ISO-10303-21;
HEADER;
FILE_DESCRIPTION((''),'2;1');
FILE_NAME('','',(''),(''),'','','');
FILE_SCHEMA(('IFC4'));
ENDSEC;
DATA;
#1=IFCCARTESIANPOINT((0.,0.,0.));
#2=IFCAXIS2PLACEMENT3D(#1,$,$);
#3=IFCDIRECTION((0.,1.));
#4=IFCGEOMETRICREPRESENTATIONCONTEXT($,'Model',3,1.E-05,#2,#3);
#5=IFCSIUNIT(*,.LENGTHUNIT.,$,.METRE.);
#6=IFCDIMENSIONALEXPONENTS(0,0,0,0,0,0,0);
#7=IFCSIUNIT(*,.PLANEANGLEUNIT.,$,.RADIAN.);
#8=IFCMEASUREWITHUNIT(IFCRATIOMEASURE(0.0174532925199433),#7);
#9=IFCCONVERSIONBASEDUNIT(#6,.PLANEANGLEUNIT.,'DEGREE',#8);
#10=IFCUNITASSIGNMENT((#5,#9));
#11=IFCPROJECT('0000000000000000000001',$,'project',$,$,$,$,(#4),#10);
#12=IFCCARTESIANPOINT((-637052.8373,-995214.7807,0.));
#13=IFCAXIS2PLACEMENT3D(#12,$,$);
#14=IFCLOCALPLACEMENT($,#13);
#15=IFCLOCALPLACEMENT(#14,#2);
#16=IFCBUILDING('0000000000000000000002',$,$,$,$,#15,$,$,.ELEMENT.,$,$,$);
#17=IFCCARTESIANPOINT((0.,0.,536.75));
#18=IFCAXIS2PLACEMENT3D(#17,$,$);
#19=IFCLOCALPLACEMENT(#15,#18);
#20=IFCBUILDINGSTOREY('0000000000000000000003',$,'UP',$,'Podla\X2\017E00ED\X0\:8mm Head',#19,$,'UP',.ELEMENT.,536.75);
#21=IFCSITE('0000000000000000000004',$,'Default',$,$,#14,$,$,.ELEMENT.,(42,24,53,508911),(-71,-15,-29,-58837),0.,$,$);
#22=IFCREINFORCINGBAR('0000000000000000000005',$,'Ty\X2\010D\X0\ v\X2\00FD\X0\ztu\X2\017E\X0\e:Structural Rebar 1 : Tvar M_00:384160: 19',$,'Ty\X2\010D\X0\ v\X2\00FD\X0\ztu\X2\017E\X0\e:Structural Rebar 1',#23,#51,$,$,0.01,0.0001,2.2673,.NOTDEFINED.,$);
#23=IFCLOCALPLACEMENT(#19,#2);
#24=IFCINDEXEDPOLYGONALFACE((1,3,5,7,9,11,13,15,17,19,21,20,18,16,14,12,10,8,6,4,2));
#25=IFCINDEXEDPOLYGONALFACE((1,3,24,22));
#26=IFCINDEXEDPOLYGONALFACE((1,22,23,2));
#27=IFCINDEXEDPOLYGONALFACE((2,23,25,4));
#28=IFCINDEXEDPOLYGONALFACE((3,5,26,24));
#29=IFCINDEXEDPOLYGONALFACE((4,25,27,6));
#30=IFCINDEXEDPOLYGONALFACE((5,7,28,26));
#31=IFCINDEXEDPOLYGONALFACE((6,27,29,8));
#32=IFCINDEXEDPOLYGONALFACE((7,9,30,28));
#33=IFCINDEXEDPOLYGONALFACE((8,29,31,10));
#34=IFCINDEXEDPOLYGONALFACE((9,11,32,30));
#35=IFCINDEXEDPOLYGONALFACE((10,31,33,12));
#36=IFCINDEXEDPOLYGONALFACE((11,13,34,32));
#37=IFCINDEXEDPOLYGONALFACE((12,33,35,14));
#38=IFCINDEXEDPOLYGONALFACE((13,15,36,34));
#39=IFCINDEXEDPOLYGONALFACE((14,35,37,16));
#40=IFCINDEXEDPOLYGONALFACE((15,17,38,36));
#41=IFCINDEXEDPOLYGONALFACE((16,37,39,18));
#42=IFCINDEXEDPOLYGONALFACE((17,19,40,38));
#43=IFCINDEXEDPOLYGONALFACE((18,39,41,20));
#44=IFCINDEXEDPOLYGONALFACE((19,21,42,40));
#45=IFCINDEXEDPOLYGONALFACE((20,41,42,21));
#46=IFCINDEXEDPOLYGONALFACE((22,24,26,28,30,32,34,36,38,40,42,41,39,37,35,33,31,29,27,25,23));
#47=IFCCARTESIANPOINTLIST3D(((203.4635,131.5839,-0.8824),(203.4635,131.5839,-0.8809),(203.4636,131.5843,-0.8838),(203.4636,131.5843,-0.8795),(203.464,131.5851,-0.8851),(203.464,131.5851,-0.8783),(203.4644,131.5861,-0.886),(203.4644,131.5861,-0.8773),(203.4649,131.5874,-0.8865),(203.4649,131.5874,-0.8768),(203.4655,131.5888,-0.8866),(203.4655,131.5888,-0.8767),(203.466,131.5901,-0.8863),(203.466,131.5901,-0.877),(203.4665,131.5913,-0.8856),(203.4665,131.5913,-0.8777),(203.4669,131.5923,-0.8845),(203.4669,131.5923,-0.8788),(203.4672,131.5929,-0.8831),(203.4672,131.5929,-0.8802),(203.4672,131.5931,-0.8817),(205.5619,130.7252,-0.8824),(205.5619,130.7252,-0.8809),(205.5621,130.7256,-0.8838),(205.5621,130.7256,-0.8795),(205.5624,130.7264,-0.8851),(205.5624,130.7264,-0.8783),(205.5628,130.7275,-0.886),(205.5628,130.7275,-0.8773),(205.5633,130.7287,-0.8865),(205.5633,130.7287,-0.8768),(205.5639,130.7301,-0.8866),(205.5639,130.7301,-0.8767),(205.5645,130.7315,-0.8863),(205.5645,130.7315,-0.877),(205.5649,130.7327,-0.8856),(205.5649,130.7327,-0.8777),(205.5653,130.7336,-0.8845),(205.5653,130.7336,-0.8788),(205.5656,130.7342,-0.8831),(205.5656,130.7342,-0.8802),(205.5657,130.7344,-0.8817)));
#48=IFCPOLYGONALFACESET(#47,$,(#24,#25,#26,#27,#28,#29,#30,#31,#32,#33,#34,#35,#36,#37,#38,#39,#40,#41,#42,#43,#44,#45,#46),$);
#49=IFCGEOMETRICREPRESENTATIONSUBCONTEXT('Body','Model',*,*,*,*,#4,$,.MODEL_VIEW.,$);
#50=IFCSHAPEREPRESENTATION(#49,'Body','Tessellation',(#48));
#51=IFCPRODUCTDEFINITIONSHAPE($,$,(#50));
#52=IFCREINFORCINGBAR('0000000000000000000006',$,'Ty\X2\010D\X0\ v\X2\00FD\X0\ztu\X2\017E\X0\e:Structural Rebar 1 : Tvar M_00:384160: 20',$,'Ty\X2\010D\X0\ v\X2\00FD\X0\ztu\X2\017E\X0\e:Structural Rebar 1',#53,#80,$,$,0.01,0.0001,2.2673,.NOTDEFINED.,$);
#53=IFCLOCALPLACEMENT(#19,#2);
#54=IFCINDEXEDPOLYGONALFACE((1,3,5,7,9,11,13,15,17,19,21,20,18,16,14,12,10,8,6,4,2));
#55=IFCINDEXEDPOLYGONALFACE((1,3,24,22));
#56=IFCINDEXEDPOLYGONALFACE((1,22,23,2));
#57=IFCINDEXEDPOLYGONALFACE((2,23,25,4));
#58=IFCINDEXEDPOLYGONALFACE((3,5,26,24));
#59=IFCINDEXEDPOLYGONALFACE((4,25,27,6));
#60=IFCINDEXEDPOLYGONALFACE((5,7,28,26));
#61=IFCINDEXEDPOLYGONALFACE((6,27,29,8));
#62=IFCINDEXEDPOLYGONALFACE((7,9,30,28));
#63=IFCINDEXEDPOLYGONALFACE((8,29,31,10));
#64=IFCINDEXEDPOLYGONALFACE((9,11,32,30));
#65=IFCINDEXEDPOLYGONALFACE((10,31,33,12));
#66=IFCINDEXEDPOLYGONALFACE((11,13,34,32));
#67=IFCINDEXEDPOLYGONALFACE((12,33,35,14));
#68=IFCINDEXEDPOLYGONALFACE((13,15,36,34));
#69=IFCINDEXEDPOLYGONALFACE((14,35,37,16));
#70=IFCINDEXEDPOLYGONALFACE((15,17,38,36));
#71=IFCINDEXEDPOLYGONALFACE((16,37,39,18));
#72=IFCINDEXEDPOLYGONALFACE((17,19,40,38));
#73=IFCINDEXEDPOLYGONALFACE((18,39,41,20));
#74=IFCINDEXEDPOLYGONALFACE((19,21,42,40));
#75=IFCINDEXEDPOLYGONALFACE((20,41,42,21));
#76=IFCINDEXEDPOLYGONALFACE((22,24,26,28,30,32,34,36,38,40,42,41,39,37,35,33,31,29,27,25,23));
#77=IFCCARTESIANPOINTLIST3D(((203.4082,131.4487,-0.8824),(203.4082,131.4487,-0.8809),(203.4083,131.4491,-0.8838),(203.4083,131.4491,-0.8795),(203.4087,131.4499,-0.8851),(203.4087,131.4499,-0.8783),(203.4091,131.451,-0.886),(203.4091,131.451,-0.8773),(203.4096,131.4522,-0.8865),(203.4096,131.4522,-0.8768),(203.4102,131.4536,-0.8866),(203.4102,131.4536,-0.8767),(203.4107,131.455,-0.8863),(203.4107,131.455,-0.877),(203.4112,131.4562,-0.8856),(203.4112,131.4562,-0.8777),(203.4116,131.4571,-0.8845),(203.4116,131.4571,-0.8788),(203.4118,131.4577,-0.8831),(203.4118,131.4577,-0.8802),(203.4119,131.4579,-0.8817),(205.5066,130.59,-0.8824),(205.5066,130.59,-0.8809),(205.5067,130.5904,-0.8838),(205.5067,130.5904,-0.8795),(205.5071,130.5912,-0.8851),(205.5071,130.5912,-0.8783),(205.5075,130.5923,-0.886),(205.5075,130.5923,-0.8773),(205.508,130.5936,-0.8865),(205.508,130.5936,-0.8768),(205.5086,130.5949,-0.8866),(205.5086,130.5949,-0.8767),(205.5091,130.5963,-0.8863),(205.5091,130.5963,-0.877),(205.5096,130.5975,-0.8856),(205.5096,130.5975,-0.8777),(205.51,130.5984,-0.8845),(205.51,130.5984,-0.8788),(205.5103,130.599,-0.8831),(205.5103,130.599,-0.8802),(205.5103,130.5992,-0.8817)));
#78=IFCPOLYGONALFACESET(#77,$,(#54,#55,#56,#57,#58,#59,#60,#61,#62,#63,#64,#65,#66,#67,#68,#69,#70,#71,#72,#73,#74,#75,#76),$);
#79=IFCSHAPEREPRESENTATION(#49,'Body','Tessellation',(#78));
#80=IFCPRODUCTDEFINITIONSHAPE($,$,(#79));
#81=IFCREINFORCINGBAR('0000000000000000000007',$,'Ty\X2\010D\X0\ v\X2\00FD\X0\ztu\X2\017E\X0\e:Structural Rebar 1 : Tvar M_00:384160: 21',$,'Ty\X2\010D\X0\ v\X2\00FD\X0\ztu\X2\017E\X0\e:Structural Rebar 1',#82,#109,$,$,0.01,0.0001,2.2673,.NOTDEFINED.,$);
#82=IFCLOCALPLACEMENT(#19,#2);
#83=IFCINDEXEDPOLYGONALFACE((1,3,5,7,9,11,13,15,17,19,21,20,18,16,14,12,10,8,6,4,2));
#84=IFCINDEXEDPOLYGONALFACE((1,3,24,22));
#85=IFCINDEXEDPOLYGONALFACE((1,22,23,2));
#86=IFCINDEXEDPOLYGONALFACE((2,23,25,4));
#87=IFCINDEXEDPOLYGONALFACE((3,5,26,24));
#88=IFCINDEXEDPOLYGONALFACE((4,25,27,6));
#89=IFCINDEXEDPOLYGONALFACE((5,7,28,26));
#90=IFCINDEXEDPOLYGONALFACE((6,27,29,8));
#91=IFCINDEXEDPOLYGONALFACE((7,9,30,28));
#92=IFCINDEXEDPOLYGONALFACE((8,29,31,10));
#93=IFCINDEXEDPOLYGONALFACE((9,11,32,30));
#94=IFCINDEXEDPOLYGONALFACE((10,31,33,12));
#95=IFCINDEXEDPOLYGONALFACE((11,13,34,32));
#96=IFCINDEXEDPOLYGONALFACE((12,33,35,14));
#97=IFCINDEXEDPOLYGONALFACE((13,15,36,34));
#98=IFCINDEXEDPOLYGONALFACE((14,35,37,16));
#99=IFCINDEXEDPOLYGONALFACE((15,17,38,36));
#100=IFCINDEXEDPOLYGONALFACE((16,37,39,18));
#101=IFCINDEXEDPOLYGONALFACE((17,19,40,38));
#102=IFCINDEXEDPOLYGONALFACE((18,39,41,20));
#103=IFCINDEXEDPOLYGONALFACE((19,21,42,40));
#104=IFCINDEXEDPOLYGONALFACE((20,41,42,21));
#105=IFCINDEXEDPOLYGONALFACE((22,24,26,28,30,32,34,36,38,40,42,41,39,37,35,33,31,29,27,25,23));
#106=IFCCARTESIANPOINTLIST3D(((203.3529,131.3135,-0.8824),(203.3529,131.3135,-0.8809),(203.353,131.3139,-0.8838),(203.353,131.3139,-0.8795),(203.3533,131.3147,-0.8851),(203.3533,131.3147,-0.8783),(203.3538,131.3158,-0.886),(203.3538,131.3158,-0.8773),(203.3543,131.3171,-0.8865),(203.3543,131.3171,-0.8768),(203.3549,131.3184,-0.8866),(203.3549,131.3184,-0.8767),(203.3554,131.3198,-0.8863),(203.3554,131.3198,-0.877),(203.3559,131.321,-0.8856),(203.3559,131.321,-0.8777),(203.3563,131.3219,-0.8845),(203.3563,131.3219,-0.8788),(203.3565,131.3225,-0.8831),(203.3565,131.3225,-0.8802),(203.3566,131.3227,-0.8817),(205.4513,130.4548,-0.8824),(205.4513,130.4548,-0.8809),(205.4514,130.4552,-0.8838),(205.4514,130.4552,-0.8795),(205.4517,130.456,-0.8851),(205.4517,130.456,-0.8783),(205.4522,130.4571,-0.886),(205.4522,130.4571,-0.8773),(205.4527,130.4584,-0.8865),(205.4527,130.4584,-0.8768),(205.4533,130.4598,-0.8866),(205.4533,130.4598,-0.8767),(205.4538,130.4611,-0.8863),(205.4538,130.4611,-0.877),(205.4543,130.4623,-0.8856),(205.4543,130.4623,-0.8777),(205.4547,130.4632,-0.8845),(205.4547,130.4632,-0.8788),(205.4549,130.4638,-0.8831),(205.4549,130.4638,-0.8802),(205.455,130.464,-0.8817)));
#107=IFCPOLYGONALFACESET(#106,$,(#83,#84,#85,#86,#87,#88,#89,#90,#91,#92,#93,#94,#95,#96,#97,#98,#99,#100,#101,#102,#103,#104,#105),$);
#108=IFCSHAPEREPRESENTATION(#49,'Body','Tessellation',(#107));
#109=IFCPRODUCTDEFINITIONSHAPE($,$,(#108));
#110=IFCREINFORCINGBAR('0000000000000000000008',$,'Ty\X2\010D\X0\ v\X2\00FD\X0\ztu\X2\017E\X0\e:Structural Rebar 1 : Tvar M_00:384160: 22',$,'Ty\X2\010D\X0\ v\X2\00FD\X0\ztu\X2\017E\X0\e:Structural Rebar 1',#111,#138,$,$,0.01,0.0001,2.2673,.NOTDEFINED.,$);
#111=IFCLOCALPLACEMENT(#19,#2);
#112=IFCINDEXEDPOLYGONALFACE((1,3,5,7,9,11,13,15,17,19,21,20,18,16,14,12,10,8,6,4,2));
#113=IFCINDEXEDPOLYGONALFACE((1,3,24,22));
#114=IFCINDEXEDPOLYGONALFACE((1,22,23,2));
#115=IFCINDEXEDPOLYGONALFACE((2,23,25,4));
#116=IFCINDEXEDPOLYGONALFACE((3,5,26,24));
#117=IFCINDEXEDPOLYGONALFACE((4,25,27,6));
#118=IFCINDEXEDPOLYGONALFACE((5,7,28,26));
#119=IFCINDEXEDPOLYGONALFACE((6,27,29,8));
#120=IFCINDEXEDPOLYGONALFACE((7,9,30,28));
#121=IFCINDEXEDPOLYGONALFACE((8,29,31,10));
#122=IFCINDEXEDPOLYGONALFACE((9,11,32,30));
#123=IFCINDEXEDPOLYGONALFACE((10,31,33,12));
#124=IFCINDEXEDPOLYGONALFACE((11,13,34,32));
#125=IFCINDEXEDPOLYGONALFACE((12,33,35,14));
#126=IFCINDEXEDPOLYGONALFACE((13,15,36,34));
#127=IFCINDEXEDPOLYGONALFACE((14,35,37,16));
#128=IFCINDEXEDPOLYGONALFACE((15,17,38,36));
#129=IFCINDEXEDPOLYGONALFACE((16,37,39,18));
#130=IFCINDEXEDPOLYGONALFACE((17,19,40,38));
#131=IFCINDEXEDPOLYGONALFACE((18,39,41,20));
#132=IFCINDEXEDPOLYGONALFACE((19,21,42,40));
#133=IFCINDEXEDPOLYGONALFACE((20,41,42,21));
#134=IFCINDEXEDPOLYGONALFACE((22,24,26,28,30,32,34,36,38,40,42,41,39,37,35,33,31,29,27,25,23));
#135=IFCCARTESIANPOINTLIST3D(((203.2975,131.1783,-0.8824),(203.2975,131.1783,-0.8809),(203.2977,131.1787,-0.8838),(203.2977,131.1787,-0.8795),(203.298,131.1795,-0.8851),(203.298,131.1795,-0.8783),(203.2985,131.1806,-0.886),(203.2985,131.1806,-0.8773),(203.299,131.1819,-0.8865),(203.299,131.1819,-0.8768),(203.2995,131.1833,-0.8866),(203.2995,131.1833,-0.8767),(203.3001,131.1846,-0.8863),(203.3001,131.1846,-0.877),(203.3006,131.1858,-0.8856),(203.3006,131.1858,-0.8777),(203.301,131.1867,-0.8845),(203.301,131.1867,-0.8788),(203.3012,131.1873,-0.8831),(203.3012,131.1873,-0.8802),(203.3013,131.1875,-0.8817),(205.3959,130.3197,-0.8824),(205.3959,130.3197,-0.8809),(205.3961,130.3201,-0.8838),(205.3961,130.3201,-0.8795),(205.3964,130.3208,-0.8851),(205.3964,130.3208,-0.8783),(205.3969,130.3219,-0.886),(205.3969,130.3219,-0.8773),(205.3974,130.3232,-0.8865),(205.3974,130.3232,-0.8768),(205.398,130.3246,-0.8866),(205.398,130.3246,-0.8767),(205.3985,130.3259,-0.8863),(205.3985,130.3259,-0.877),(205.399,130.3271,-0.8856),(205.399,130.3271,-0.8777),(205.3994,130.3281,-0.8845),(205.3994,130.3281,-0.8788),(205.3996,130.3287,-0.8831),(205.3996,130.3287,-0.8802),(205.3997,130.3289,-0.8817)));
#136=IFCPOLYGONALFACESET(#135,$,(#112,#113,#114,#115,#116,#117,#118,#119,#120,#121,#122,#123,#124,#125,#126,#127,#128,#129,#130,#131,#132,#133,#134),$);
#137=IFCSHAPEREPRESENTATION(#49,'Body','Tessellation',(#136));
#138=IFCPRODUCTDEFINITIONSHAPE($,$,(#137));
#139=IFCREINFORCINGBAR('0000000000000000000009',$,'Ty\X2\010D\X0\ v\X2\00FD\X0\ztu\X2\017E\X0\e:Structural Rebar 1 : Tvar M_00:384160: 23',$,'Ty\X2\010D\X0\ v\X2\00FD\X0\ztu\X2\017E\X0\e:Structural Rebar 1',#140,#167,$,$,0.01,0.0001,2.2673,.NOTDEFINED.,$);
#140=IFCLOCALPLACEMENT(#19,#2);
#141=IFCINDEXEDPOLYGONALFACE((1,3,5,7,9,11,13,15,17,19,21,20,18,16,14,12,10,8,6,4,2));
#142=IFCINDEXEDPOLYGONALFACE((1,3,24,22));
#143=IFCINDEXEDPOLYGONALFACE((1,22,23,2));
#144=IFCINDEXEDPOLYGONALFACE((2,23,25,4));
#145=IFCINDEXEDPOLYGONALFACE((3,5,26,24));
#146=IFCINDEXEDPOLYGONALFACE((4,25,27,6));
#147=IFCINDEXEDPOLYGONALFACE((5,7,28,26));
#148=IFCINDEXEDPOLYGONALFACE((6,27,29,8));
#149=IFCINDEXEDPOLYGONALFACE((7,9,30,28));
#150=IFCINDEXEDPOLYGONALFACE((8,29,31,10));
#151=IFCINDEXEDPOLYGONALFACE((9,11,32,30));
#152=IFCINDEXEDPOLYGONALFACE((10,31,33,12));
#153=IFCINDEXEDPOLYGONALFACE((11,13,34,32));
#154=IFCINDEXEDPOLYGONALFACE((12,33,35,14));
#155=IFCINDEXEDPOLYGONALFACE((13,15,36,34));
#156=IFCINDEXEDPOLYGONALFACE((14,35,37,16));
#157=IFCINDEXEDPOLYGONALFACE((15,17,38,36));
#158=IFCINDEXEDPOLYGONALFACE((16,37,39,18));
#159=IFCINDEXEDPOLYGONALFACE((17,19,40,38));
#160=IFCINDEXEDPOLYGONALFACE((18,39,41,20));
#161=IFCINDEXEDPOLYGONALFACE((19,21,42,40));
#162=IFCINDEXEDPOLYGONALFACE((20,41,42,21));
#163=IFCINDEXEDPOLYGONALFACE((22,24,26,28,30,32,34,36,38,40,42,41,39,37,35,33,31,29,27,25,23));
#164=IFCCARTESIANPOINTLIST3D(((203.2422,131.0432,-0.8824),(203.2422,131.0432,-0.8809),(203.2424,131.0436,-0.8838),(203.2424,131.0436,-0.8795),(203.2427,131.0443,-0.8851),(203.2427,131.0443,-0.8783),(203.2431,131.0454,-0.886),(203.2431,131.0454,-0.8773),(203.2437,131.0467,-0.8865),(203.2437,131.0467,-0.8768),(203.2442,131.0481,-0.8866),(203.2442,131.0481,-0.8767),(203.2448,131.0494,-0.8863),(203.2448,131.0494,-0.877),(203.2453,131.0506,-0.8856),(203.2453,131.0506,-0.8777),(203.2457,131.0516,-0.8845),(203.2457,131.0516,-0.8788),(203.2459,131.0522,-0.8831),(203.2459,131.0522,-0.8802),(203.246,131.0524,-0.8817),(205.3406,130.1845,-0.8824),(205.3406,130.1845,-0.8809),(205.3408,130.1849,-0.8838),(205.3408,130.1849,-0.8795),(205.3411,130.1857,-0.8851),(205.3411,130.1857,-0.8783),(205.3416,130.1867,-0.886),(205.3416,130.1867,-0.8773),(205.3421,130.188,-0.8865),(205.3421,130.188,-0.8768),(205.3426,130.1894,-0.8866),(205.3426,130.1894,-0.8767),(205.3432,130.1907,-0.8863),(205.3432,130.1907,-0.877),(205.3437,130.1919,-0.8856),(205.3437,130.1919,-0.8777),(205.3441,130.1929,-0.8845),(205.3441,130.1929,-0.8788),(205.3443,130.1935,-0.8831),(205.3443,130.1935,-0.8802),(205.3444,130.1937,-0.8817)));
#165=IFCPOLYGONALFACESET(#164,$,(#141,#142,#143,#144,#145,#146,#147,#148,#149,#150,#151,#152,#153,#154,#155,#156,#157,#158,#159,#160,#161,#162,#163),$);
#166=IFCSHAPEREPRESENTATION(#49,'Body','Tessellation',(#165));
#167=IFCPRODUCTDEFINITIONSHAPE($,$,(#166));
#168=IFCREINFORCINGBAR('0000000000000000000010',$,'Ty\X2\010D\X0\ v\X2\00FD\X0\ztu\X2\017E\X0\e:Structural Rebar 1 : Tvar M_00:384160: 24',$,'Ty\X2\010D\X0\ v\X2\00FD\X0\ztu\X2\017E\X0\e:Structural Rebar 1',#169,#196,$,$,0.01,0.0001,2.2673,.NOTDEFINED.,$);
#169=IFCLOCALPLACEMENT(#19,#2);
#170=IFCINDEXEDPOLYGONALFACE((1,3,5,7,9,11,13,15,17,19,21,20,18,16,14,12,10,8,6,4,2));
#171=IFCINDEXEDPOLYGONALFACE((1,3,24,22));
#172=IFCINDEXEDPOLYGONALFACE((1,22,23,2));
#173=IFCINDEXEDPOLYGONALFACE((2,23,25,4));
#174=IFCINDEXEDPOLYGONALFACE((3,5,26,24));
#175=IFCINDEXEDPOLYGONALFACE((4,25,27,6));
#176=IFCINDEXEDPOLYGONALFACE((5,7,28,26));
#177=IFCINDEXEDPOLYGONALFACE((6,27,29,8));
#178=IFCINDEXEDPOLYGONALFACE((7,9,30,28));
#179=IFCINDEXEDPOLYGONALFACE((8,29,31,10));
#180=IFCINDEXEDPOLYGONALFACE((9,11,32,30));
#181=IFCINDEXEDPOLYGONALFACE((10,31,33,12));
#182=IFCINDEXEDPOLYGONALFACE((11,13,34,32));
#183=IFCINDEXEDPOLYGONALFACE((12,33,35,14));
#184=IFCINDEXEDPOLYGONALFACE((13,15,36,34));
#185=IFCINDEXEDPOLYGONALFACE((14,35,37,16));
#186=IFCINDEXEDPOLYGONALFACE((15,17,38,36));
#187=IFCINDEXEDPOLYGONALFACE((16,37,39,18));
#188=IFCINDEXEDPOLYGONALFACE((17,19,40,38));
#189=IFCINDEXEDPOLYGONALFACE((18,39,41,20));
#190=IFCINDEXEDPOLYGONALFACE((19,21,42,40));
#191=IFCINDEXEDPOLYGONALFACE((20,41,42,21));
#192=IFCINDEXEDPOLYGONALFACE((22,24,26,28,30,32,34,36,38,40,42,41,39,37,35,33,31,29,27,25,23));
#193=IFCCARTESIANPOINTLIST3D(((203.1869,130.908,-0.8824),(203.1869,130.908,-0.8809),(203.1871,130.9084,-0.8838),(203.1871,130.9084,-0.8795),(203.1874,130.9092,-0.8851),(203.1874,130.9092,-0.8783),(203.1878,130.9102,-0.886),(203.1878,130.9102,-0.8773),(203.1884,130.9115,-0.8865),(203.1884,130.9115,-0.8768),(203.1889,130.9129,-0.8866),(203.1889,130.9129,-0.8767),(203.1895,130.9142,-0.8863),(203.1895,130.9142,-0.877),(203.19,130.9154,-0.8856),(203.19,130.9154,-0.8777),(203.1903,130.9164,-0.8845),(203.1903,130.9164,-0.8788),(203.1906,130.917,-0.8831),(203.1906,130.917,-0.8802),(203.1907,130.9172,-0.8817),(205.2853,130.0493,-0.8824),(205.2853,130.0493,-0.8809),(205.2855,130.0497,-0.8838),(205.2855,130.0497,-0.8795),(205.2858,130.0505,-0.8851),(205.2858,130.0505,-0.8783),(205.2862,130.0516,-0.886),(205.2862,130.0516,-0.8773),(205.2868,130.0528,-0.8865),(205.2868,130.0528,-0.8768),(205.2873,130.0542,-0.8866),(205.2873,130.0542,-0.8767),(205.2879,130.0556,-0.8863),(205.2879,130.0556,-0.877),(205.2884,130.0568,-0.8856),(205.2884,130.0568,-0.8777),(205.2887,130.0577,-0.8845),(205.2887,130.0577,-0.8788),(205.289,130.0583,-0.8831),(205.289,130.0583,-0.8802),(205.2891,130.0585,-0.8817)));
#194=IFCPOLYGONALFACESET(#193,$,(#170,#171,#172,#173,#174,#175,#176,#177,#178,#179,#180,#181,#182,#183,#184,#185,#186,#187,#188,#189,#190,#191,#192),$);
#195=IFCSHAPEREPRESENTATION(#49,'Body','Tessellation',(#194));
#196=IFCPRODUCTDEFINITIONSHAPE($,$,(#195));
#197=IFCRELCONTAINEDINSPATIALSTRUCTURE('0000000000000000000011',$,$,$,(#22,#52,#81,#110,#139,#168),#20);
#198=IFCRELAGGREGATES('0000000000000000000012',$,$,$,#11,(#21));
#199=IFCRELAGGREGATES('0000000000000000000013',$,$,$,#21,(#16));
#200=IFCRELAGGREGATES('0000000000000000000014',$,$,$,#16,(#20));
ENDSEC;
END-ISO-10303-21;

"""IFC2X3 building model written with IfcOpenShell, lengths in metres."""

from ifc_helpers import new_model, entity, si_unit, converted_unit, direction, frame, origin, place, context, subcontext, project, spatial, element, save


model = new_model("IFC2X3")

# Units and contexts
model_context = context("Model", 3, precision=1e-05, world=origin(), true_north=direction((0.0, 1.0)))
body_context = subcontext(model_context, "Body", "Model", "MODEL_VIEW")
ifc_project = project(units=[si_unit("LENGTHUNIT", "METRE"), converted_unit("PLANEANGLEUNIT", "DEGREE", entity("IfcRatioMeasure", 0.0174532925199433), si_unit("PLANEANGLEUNIT", "RADIAN"), dimensions=[0, 0, 0, 0, 0, 0, 0])], contexts=[model_context])

# Site, building, storey
site_placement = place(None, frame((-637052.8373, -995214.7807, 0.0)))
site = spatial("IfcSite", under=ifc_project, at=site_placement, Name="Default", CompositionType="ELEMENT", RefLatitude=(42, 24, 53, 508911), RefLongitude=(-71, -15, -29, -58837), RefElevation=0.0)
building_placement = place(site_placement, origin())
building = spatial("IfcBuilding", under=site, at=building_placement, CompositionType="ELEMENT")
storey_placement = place(building_placement, frame((0.0, 0.0, 536.75)))
storey = spatial("IfcBuildingStorey", under=building, at=storey_placement, Name="UP", ObjectType="Podlaží:8mm Head", LongName="UP", CompositionType="ELEMENT", Elevation=536.75)

# Reinforcing bars
reinforcing_bar_1_placement = place(storey_placement, origin())
element("IfcReinforcingBar", 1, at=reinforcing_bar_1_placement, inside=storey, Name="Tyč výztuže:Structural Rebar 1 : Tvar M_00:384160: 19", ObjectType="Tyč výztuže:Structural Rebar 1", BarLength=2.2673, BarRole="NOTDEFINED", CrossSectionArea=0.0001, NominalDiameter=0.01, context=body_context, shape_type="AdvancedSweptSolid", body=[
    entity("IfcSweptDiskSolid", entity("IfcCompositeCurve", [entity("IfcCompositeCurveSegment", "CONTINUOUS", True, entity("IfcPolyline", [entity("IfcCartesianPoint", [-205.5638, -130.7298, 0.8817]), entity("IfcCartesianPoint", [-203.4654, -131.5885, 0.8817])]))], False), 0.005, None, 0.0, 1.0),
])
reinforcing_bar_2_placement = place(storey_placement, origin())
element("IfcReinforcingBar", 2, at=reinforcing_bar_2_placement, inside=storey, Name="Tyč výztuže:Structural Rebar 1 : Tvar M_00:384160: 20", ObjectType="Tyč výztuže:Structural Rebar 1", BarLength=2.2673, BarRole="NOTDEFINED", CrossSectionArea=0.0001, NominalDiameter=0.01, context=body_context, shape_type="AdvancedSweptSolid", body=[
    entity("IfcSweptDiskSolid", entity("IfcCompositeCurve", [entity("IfcCompositeCurveSegment", "CONTINUOUS", True, entity("IfcPolyline", [entity("IfcCartesianPoint", [-205.5084, -130.5946, 0.8817]), entity("IfcCartesianPoint", [-203.41, -131.4533, 0.8817])]))], False), 0.005, None, 0.0, 1.0),
])
reinforcing_bar_3_placement = place(storey_placement, origin())
element("IfcReinforcingBar", 3, at=reinforcing_bar_3_placement, inside=storey, Name="Tyč výztuže:Structural Rebar 1 : Tvar M_00:384160: 21", ObjectType="Tyč výztuže:Structural Rebar 1", BarLength=2.2673, BarRole="NOTDEFINED", CrossSectionArea=0.0001, NominalDiameter=0.01, context=body_context, shape_type="AdvancedSweptSolid", body=[
    entity("IfcSweptDiskSolid", entity("IfcCompositeCurve", [entity("IfcCompositeCurveSegment", "CONTINUOUS", True, entity("IfcPolyline", [entity("IfcCartesianPoint", [-205.4531, -130.4594, 0.8817]), entity("IfcCartesianPoint", [-203.3547, -131.3181, 0.8817])]))], False), 0.005, None, 0.0, 1.0),
])
reinforcing_bar_4_placement = place(storey_placement, origin())
element("IfcReinforcingBar", 4, at=reinforcing_bar_4_placement, inside=storey, Name="Tyč výztuže:Structural Rebar 1 : Tvar M_00:384160: 22", ObjectType="Tyč výztuže:Structural Rebar 1", BarLength=2.2673, BarRole="NOTDEFINED", CrossSectionArea=0.0001, NominalDiameter=0.01, context=body_context, shape_type="AdvancedSweptSolid", body=[
    entity("IfcSweptDiskSolid", entity("IfcCompositeCurve", [entity("IfcCompositeCurveSegment", "CONTINUOUS", True, entity("IfcPolyline", [entity("IfcCartesianPoint", [-205.3978, -130.3242, 0.8817]), entity("IfcCartesianPoint", [-203.2994, -131.1829, 0.8817])]))], False), 0.005, None, 0.0, 1.0),
])
reinforcing_bar_5_placement = place(storey_placement, origin())
element("IfcReinforcingBar", 5, at=reinforcing_bar_5_placement, inside=storey, Name="Tyč výztuže:Structural Rebar 1 : Tvar M_00:384160: 23", ObjectType="Tyč výztuže:Structural Rebar 1", BarLength=2.2673, BarRole="NOTDEFINED", CrossSectionArea=0.0001, NominalDiameter=0.01, context=body_context, shape_type="AdvancedSweptSolid", body=[
    entity("IfcSweptDiskSolid", entity("IfcCompositeCurve", [entity("IfcCompositeCurveSegment", "CONTINUOUS", True, entity("IfcPolyline", [entity("IfcCartesianPoint", [-205.3425, -130.1891, 0.8817]), entity("IfcCartesianPoint", [-203.2441, -131.0477, 0.8817])]))], False), 0.005, None, 0.0, 1.0),
])
reinforcing_bar_6_placement = place(storey_placement, origin())
element("IfcReinforcingBar", 6, at=reinforcing_bar_6_placement, inside=storey, Name="Tyč výztuže:Structural Rebar 1 : Tvar M_00:384160: 24", ObjectType="Tyč výztuže:Structural Rebar 1", BarLength=2.2673, BarRole="NOTDEFINED", CrossSectionArea=0.0001, NominalDiameter=0.01, context=body_context, shape_type="AdvancedSweptSolid", body=[
    entity("IfcSweptDiskSolid", entity("IfcCompositeCurve", [entity("IfcCompositeCurveSegment", "CONTINUOUS", True, entity("IfcPolyline", [entity("IfcCartesianPoint", [-205.2872, -130.0539, 0.8817]), entity("IfcCartesianPoint", [-203.1888, -130.9125, 0.8817])]))], False), 0.005, None, 0.0, 1.0),
])

save(model, "model.ifc")
